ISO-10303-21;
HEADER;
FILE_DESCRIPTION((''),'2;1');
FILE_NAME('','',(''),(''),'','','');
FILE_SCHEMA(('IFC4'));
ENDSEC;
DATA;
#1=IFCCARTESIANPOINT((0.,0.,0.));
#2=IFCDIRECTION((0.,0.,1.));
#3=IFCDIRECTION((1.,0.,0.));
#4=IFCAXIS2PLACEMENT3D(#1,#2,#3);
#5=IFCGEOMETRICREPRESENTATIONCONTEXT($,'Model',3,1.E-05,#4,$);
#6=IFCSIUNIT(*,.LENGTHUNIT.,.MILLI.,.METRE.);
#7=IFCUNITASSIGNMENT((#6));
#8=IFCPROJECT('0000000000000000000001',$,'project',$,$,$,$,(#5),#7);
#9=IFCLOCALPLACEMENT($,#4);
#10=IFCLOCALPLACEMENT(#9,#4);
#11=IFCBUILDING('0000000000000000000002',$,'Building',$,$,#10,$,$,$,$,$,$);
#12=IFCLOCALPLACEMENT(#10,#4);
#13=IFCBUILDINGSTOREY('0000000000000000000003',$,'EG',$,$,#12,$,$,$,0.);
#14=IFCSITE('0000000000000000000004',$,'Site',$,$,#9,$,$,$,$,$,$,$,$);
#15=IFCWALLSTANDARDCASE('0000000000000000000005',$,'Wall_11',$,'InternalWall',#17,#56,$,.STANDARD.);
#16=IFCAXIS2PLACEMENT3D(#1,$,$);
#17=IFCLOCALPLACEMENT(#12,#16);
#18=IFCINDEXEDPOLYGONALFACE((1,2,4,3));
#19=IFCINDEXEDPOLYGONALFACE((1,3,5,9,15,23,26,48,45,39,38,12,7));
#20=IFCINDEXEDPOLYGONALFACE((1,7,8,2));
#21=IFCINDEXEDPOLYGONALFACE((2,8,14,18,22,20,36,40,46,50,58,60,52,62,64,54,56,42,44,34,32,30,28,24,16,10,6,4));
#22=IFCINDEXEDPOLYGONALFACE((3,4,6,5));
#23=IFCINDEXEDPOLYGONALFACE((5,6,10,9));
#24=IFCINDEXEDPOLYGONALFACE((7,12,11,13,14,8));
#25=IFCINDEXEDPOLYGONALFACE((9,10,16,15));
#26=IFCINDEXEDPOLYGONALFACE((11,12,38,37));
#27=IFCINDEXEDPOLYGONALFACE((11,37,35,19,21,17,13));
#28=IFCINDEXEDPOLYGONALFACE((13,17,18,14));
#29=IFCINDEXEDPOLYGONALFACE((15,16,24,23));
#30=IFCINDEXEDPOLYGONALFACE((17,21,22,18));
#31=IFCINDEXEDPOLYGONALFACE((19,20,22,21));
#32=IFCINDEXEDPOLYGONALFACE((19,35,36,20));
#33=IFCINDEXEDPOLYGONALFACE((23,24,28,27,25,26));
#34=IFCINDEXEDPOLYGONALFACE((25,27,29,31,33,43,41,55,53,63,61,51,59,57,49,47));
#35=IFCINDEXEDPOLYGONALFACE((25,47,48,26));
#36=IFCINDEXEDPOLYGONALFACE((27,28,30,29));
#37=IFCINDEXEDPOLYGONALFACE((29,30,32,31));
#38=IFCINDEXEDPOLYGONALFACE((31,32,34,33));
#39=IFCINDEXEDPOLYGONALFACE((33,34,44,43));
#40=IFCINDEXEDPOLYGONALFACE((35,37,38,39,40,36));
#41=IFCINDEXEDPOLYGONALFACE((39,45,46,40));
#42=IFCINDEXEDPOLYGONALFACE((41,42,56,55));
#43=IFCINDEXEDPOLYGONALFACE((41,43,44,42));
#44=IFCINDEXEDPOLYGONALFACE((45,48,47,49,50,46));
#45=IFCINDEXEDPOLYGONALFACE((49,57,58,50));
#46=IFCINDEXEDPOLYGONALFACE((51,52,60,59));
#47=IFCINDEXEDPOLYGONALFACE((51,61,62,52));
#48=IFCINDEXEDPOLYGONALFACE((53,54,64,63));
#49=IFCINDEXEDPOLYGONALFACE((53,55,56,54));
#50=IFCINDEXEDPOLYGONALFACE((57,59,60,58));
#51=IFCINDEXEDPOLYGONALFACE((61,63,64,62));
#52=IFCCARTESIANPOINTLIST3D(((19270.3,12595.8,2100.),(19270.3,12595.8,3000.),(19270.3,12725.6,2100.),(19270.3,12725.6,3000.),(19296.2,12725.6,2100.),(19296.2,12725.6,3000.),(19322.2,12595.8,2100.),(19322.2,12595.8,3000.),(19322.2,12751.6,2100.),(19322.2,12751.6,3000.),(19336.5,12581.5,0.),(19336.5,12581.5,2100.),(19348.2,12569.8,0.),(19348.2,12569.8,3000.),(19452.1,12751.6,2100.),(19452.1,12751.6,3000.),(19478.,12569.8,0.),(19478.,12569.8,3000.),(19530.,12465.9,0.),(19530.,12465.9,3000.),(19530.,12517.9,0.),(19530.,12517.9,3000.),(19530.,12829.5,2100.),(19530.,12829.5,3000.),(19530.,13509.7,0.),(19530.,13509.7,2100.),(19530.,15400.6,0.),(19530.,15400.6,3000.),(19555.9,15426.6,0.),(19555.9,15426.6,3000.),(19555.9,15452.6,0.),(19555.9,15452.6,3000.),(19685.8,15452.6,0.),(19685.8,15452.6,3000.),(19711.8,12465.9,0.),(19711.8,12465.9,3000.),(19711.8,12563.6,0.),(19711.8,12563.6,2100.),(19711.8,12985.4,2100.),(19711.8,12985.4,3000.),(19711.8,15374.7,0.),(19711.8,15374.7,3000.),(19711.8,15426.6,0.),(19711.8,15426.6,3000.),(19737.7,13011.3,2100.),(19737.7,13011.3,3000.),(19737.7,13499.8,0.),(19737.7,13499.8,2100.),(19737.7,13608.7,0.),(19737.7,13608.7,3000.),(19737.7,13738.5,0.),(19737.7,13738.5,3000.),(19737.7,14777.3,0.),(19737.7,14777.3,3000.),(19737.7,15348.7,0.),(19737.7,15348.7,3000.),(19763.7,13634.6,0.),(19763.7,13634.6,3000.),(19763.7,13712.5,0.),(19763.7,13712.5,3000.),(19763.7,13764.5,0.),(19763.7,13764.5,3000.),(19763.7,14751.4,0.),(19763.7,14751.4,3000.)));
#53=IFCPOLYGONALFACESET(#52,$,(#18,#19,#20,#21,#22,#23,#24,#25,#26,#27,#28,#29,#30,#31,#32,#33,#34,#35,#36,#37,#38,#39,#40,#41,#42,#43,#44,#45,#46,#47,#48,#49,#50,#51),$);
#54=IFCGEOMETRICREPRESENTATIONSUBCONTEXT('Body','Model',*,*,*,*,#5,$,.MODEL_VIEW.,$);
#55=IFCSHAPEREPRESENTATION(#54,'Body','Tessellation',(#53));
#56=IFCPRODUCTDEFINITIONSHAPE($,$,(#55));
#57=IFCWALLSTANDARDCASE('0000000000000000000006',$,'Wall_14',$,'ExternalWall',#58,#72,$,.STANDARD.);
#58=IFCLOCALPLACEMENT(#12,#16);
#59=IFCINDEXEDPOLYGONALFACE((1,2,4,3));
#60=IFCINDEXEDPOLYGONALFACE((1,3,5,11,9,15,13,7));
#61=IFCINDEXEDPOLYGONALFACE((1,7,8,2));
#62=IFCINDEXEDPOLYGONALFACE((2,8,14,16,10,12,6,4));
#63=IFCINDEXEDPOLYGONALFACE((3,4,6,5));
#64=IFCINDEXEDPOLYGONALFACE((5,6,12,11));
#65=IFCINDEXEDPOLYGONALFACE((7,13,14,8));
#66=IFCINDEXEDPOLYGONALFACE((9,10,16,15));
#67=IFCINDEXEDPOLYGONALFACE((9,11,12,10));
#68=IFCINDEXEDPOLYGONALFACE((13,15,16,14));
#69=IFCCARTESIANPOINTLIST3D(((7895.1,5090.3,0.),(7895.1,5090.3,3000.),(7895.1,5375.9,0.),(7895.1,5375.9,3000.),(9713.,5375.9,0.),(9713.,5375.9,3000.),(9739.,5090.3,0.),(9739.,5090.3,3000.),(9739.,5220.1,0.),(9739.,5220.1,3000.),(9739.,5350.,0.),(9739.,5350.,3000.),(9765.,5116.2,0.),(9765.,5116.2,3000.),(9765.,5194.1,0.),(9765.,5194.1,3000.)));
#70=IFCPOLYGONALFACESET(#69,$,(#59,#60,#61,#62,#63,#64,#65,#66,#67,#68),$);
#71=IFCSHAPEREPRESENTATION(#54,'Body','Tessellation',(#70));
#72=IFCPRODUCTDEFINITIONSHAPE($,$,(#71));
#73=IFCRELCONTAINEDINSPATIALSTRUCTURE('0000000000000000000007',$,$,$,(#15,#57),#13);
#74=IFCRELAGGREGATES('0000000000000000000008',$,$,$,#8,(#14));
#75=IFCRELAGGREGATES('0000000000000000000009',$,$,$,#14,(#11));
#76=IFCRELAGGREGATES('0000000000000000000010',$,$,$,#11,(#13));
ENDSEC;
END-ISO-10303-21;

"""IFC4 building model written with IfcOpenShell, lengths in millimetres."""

from ifc_helpers import new_model, si_unit, frame, origin_with_axes, place, context, subcontext, project, spatial, polyline, rectangle, outline, extrude, element, save


model = new_model("IFC4")

# Units and contexts
model_context = context("Model", 3, precision=1e-05, world=origin_with_axes())
body_context = subcontext(model_context, "Body", "Model", "MODEL_VIEW")
ifc_project = project(units=[si_unit("LENGTHUNIT", "METRE", prefix="MILLI")], contexts=[model_context])

# Site, building, storey
site_placement = place(None, origin_with_axes())
site = spatial("IfcSite", under=ifc_project, at=site_placement, Name="Site")
building_placement = place(site_placement, origin_with_axes())
building = spatial("IfcBuilding", under=site, at=building_placement, Name="Building")
storey_placement = place(building_placement, origin_with_axes())
storey = spatial("IfcBuildingStorey", under=building, at=storey_placement, Name="EG", Elevation=0.0)

# Walls, openings
wall_1_placement = place(storey_placement, origin_with_axes())
wall_1 = element("IfcWallStandardCase", 1, at=wall_1_placement, inside=storey, Name="Wall_11", ObjectType="InternalWall", PredefinedType="STANDARD", context=body_context, shape_type="SweptSolid", body=[
    extrude(outline(polyline([(19530.0, 12465.9, 0.0), (19530.0, 12517.9, 0.0), (19478.0, 12569.8, 0.0), (19348.2, 12569.8, 0.0), (19322.2, 12595.8, 0.0), (19270.3, 12595.8, 0.0), (19270.3, 12725.6, 0.0), (19296.2, 12725.6, 0.0), (19322.2, 12751.6, 0.0), (19452.1, 12751.6, 0.0), (19530.0, 12829.5, 0.0), (19530.0, 15400.6, 0.0), (19555.9, 15426.6, 0.0), (19555.9, 15452.6, 0.0), (19685.8, 15452.6, 0.0), (19711.8, 15426.6, 0.0), (19711.8, 15374.7, 0.0), (19737.7, 15348.7, 0.0), (19737.7, 14777.3, 0.0), (19763.7, 14751.4, 0.0), (19763.7, 13764.5, 0.0), (19737.7, 13738.5, 0.0), (19763.7, 13712.5, 0.0), (19763.7, 13634.6, 0.0), (19737.7, 13608.7, 0.0), (19737.7, 13011.3, 0.0), (19711.8, 12985.4, 0.0), (19711.8, 12465.9, 0.0), (19530.0, 12465.9, 0.0)])), origin_with_axes(), (0.0, 0.0, 1.0), 3000.0),
])
opening_1_placement = place(wall_1_placement, origin_with_axes())
element("IfcOpeningElement", 2, at=opening_1_placement, inside=storey, cuts=wall_1, context=body_context, shape_type="SweptSolid", body=[
    extrude(rectangle(XDim=936.4, YDim=453.4), frame((19512.3, 13041.9, 0.0), z_axis=(0.0, 0.0, 1.0), x_axis=(-0.047565, -0.998868, 0.0)), (0.0, 0.0, 1.0), 2100.0),
])
wall_2_placement = place(storey_placement, origin_with_axes())
wall_2 = element("IfcWallStandardCase", 3, at=wall_2_placement, inside=storey, Name="Wall_14", ObjectType="ExternalWall", PredefinedType="STANDARD", context=body_context, shape_type="SweptSolid", body=[
    extrude(outline(polyline([(7895.1, 5090.3, 0.0), (7895.1, 5375.9, 0.0), (9713.0, 5375.9, 0.0), (9739.0, 5350.0, 0.0), (9739.0, 5220.1, 0.0), (9765.0, 5194.1, 0.0), (9765.0, 5116.2, 0.0), (9739.0, 5090.3, 0.0), (7895.1, 5090.3, 0.0)])), origin_with_axes(), (0.0, 0.0, 1.0), 3000.0),
])
opening_2_placement = place(wall_2_placement, origin_with_axes())
element("IfcOpeningElement", 4, at=opening_2_placement, inside=storey, cuts=wall_2, context=body_context, shape_type="SweptSolid", body=[
    extrude(rectangle(XDim=1200.0, YDim=285.7), frame((10439.6, 5233.0, 800.0), z_axis=(0.0, 0.0, 1.0), x_axis=(1.0, 0.0, 0.0)), (0.0, 0.0, 1.0), 1200.0),
])

save(model, "model.ifc")
